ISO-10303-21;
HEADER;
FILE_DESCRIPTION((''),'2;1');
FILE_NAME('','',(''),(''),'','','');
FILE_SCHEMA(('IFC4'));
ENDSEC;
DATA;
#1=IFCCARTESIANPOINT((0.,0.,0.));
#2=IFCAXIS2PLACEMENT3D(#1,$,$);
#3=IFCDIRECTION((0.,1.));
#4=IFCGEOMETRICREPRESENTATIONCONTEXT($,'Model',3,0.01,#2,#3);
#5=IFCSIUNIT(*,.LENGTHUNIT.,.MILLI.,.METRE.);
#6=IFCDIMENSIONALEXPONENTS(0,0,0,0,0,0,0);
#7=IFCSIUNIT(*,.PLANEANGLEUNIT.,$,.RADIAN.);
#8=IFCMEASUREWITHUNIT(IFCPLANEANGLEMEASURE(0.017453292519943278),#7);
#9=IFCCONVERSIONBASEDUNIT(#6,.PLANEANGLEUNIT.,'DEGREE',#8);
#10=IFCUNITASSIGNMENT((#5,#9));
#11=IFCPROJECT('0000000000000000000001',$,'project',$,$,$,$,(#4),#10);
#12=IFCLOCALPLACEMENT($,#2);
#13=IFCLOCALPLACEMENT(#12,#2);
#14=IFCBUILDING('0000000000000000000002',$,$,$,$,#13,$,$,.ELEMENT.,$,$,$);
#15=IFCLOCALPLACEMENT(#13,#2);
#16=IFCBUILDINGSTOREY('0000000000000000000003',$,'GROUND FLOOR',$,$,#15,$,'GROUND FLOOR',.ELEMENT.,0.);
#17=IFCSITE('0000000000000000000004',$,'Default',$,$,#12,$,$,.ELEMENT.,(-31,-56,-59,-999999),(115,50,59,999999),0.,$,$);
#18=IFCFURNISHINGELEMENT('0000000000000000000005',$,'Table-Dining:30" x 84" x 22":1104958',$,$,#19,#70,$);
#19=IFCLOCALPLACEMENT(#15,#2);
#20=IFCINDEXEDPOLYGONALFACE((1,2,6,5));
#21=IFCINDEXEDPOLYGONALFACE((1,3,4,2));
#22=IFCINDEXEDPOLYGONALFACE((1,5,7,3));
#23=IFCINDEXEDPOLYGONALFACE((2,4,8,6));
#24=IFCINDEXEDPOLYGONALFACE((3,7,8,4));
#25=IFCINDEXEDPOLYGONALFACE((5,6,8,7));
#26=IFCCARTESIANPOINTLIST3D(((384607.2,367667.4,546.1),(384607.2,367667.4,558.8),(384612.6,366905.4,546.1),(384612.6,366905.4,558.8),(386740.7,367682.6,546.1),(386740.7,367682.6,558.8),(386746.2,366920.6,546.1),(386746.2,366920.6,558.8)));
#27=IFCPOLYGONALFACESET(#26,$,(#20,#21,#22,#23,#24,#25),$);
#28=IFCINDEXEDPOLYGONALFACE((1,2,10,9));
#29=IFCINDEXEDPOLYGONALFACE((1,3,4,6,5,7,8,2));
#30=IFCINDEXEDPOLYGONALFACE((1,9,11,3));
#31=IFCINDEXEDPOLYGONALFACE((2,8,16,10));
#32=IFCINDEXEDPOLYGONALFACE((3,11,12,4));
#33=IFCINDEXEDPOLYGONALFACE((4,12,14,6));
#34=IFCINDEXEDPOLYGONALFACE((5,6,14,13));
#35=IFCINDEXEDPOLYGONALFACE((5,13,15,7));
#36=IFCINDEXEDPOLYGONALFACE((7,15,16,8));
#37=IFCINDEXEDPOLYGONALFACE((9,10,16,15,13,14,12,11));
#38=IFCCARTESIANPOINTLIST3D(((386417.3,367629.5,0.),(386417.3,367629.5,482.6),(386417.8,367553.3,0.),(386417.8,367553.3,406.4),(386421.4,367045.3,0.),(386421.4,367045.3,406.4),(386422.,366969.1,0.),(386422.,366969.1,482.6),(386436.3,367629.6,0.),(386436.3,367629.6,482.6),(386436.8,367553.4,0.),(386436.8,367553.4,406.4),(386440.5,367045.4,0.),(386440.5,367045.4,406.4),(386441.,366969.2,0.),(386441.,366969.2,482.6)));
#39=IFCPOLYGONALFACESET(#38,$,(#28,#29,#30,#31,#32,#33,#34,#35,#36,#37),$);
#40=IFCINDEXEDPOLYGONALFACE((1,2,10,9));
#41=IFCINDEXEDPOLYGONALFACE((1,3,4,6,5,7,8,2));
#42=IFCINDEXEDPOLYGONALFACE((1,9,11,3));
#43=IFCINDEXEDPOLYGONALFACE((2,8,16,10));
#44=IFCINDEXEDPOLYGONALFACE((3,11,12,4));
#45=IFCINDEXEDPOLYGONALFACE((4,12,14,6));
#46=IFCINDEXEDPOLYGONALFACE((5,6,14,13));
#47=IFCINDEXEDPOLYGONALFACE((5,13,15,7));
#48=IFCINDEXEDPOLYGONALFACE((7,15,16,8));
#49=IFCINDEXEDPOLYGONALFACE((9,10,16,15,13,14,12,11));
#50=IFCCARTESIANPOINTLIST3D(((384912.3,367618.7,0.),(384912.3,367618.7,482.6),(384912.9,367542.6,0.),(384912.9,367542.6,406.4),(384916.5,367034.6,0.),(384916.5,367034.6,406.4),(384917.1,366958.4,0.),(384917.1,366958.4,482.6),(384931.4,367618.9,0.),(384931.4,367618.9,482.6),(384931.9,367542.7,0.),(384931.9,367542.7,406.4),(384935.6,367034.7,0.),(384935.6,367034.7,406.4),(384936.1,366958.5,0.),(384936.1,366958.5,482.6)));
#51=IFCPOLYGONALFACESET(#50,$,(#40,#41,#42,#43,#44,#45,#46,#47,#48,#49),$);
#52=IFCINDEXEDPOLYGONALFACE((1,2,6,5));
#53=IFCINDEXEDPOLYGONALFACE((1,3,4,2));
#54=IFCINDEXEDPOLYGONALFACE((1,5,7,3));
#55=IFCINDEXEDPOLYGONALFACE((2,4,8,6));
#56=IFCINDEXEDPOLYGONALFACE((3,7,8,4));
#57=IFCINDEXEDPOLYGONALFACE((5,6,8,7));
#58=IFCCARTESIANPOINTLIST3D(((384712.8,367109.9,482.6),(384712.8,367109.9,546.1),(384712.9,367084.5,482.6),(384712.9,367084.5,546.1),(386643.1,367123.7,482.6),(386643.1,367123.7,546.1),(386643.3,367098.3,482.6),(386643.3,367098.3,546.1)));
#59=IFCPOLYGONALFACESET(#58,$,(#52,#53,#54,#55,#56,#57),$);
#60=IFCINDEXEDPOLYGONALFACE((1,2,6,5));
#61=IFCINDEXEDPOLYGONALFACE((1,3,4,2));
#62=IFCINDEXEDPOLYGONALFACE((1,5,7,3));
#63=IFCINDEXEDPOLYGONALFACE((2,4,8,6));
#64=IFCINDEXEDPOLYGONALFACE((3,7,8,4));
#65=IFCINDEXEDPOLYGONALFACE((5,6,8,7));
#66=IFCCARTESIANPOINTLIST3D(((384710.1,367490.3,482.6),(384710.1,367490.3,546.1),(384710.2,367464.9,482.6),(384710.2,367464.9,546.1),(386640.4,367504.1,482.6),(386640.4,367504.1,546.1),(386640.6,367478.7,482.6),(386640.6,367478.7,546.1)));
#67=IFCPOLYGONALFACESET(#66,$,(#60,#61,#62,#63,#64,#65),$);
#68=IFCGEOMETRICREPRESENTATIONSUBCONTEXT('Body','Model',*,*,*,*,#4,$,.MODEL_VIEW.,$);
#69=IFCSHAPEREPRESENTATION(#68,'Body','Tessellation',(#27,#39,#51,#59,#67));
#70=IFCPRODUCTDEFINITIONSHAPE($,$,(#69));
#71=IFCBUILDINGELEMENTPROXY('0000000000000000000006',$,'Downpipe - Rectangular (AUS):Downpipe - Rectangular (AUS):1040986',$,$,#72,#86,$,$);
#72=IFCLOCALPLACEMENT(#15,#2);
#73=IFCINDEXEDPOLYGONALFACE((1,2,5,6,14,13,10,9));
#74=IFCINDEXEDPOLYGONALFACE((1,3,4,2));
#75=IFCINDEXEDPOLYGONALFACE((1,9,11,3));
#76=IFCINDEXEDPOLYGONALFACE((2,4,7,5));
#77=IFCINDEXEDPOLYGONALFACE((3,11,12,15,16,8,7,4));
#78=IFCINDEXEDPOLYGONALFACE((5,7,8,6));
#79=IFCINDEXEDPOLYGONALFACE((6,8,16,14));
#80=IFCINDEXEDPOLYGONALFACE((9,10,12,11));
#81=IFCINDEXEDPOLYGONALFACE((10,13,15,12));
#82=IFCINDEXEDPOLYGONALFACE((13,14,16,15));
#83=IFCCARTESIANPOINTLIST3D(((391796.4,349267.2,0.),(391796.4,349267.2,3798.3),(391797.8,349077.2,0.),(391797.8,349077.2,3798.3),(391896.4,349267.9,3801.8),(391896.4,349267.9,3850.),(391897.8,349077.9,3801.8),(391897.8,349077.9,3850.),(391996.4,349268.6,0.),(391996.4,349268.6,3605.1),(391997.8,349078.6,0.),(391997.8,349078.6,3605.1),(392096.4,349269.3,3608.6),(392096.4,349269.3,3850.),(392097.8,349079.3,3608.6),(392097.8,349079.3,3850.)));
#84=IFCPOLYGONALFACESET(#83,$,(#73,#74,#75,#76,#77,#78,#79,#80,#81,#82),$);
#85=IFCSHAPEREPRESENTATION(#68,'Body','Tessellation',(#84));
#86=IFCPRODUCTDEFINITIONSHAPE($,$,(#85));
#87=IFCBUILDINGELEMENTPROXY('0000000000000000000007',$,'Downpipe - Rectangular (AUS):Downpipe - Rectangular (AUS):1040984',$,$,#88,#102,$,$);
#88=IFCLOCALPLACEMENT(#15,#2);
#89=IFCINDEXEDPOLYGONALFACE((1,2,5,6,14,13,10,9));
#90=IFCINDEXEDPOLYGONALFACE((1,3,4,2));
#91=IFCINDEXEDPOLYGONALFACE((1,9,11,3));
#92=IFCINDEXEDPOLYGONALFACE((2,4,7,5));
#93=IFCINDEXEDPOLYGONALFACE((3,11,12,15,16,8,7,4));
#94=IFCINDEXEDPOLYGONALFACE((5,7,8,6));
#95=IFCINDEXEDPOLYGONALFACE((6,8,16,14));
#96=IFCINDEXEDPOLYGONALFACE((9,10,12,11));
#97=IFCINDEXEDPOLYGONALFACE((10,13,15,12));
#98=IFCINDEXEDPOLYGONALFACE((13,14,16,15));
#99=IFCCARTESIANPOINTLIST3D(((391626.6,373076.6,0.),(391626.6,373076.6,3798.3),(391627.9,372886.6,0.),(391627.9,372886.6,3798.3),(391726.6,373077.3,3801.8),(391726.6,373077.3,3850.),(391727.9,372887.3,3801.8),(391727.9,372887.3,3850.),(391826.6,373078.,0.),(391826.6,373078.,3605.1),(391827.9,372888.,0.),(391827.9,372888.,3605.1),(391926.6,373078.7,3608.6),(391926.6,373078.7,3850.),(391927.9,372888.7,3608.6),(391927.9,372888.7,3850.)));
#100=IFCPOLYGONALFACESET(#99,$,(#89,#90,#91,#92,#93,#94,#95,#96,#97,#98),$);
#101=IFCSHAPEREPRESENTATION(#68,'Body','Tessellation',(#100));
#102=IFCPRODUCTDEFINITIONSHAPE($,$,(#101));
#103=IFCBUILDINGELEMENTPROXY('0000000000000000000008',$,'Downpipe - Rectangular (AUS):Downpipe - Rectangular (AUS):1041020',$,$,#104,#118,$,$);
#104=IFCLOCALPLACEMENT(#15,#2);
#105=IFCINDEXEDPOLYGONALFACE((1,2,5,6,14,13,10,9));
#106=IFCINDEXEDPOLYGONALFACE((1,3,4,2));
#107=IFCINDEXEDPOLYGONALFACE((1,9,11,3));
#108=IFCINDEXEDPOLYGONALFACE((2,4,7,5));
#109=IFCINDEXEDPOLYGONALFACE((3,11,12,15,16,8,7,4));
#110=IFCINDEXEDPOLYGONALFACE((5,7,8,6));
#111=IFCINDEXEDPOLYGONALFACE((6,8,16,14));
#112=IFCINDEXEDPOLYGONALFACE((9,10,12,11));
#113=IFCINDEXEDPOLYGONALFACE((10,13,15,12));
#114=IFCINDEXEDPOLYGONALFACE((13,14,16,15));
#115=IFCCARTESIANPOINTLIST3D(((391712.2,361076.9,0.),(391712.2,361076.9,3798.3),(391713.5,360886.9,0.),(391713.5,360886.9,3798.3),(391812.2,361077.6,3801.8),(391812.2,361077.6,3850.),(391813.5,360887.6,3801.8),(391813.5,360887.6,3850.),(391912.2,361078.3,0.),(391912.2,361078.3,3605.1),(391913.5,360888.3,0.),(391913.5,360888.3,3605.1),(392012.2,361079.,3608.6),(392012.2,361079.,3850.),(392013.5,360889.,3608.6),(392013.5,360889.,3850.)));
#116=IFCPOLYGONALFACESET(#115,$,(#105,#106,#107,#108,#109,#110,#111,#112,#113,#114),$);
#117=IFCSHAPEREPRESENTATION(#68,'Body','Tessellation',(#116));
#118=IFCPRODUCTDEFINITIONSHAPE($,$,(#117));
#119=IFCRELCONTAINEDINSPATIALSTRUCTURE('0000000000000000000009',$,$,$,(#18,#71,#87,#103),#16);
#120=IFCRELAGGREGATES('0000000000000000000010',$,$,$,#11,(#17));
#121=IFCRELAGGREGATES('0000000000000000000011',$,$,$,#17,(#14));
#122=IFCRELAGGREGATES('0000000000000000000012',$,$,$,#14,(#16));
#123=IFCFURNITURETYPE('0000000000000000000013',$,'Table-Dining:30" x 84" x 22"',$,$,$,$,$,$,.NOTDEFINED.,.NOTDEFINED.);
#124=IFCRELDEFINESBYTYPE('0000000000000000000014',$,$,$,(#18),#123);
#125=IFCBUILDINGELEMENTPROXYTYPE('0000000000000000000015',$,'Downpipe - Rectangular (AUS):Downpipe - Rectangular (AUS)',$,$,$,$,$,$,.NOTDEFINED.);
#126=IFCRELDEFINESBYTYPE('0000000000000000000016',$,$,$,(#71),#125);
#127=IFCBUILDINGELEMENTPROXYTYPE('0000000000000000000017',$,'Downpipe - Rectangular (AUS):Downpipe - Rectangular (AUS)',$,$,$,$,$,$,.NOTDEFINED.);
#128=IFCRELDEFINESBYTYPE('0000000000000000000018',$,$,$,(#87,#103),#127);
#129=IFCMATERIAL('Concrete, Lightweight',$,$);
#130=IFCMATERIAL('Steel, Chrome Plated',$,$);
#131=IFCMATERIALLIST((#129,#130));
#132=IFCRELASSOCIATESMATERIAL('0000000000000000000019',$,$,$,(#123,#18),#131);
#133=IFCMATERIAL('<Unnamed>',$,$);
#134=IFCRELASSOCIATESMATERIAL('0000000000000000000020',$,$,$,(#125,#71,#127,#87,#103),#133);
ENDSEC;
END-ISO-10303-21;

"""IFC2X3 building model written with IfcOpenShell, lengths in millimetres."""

from ifc_helpers import new_model, entity, si_unit, converted_unit, direction, frame, frame_2d, origin, origin_2d_with_axis, place, context, subcontext, project, spatial, polyline, rectangle, outline, extrude, source, transform, mapped, material, material_list, type_object, type_shapes, element, save


model = new_model("IFC2X3")

# Units and contexts
model_context = context("Model", 3, precision=0.01, world=origin(), true_north=direction((0.0, 1.0)))
body_context = subcontext(model_context, "Body", "Model", "MODEL_VIEW")
ifc_project = project(units=[si_unit("LENGTHUNIT", "METRE", prefix="MILLI"), converted_unit("PLANEANGLEUNIT", "DEGREE", entity("IfcPlaneAngleMeasure", 0.017453292519943278), si_unit("PLANEANGLEUNIT", "RADIAN"), dimensions=[0, 0, 0, 0, 0, 0, 0])], contexts=[model_context])

# Site, building, storey
site_placement = place(None, origin())
site = spatial("IfcSite", under=ifc_project, at=site_placement, Name="Default", CompositionType="ELEMENT", RefLatitude=(-31, -56, -59, -999999), RefLongitude=(115, 50, 59, 999999), RefElevation=0.0)
building_placement = place(site_placement, origin())
building = spatial("IfcBuilding", under=site, at=building_placement, CompositionType="ELEMENT")
storey_placement = place(building_placement, origin())
storey = spatial("IfcBuildingStorey", under=building, at=storey_placement, Name="GROUND FLOOR", LongName="GROUND FLOOR", CompositionType="ELEMENT", Elevation=0.0)

# Furnishing element
ifc_material_1 = material(Name="Steel, Chrome Plated")
ifc_material_2 = material(Name="Concrete, Lightweight")
ifc_material_list_1 = material_list([ifc_material_2, ifc_material_1])
furniture_type_1 = type_object("IfcFurnitureType", Name="Table-Dining:30\" x 84\" x 22\"", AssemblyPlace="NOTDEFINED", material=ifc_material_list_1)
shared_shape_1 = source(origin(), body_context, "Body", "SweptSolid", [
    extrude(rectangle(XDim=2133.6, YDim=762.0, at=origin_2d_with_axis()), frame((18.3, 95.2, 546.1), z_axis=(0.0, 0.0, 1.0), x_axis=(-1.0, 0.0, 0.0)), (0.0, 0.0, 1.0), 12.7),
    extrude(outline(polyline([(-330.2, -260.3), (330.2, -260.3), (330.2, 222.2), (254.0, 222.2), (254.0, -184.1), (-254.0, -184.1), (-254.0, 222.2), (-330.2, 222.2), (-330.2, -260.3)])), frame((-743.7, 95.2, 222.2), z_axis=(1.0, 0.0, 0.0), x_axis=(0.0, -1.0, 0.0)), (0.0, 0.0, 1.0), 19.1),
    extrude(outline(polyline([(-222.2, -330.2), (260.3, -330.2), (260.3, 330.2), (-222.2, 330.2), (-222.2, 254.0), (184.1, 254.0), (184.1, -254.0), (-222.2, -254.0), (-222.2, -330.2)])), frame((761.2, 95.2, 222.2), z_axis=(1.0, 0.0, 0.0), x_axis=(0.0, 0.0, 1.0)), (0.0, 0.0, 1.0), 19.1),
    extrude(rectangle(XDim=1930.4, YDim=25.4, at=frame_2d((0.0, 0.0), x_axis=(1.0, 0.0))), frame((18.3, 285.1, 482.6), z_axis=(0.0, 0.0, 1.0), x_axis=(-1.0, 0.0, 0.0)), (0.0, 0.0, 1.0), 63.5),
    extrude(rectangle(XDim=1930.4, YDim=25.4, at=origin_2d_with_axis()), frame((18.3, -95.3, 482.6), z_axis=(0.0, 0.0, 1.0), x_axis=(-1.0, 0.0, 0.0)), (0.0, 0.0, 1.0), 63.5),
])
type_shapes(furniture_type_1, [shared_shape_1])
furnishing_1_placement = place(storey_placement, frame((385694.3, 367389.3, 0.0), z_axis=(0.0, 0.0, 1.0), x_axis=(-0.999975, -0.007134, 0.0)))
element("IfcFurnishingElement", 1, at=furnishing_1_placement, inside=storey, type_object=furniture_type_1, material=ifc_material_list_1, Name="Table-Dining:30\" x 84\" x 22\":1104958", context=body_context, shape_type="MappedRepresentation", body=[
    mapped(shared_shape_1, transform((0.0, 0.0, 0.0), scale=1.0)),
])

# Building element proxies
ifc_material_3 = material(Name="<Unnamed>")
building_element_proxy_type_1 = type_object("IfcBuildingElementProxyType", Name="Downpipe - Rectangular (AUS):Downpipe - Rectangular (AUS)", PredefinedType="NOTDEFINED", material=ifc_material_3)
shared_shape_2 = source(origin(), body_context, "Body", "SweptSolid", [
    extrude(outline(polyline([(-2814.2, -150.0), (984.1, -150.0), (987.5, -50.0), (1035.8, -50.0), (1035.8, 150.0), (794.4, 150.0), (790.9, 50.0), (-2814.2, 50.0), (-2814.2, -150.0)])), frame((100.0, -95.0, 2814.2), z_axis=(0.0, 1.0, 0.0), x_axis=(0.0, 0.0, 1.0)), (0.0, 0.0, 1.0), 190.0),
])
type_shapes(building_element_proxy_type_1, [shared_shape_2])
proxy_placement = place(storey_placement, frame((391847.1, 349172.6, 0.0), z_axis=(0.0, 0.0, 1.0), x_axis=(0.999975, 0.007134, 0.0)))
element("IfcBuildingElementProxy", 2, at=proxy_placement, inside=storey, type_object=building_element_proxy_type_1, material=ifc_material_3, Name="Downpipe - Rectangular (AUS):Downpipe - Rectangular (AUS):1040986", context=body_context, shape_type="MappedRepresentation", body=[
    mapped(shared_shape_2, transform((0.0, 0.0, 0.0), scale=1.0)),
])
building_element_proxy_type_2 = type_object("IfcBuildingElementProxyType", Name="Downpipe - Rectangular (AUS):Downpipe - Rectangular (AUS)", PredefinedType="NOTDEFINED", material=ifc_material_3)
shared_shape_3 = source(origin(), body_context, "Body", "SweptSolid", [
    extrude(outline(polyline([(-50.0, -2814.2), (150.0, -2814.2), (150.0, 984.1), (50.0, 987.5), (50.0, 1035.8), (-150.0, 1035.8), (-150.0, 794.4), (-50.0, 790.9), (-50.0, -2814.2)])), frame((100.0, -95.0, 2814.2), z_axis=(0.0, 1.0, 0.0), x_axis=(-1.0, 0.0, 0.0)), (0.0, 0.0, 1.0), 190.0),
])
type_shapes(building_element_proxy_type_2, [shared_shape_3])
for number, where, z_axis, x_axis, name in (
    (3, (391677.3, 372981.9, 0.0), (0.0, 0.0, 1.0), (0.999975, 0.007134, 0.0), "Downpipe - Rectangular (AUS):Downpipe - Rectangular (AUS):1040984"),
    (4, (391762.9, 360982.3, 0.0), (0.0, 0.0, 1.0), (0.999975, 0.007134, 0.0), "Downpipe - Rectangular (AUS):Downpipe - Rectangular (AUS):1041020"),
):
    element("IfcBuildingElementProxy", number, at=place(storey_placement, frame(where, z_axis=z_axis, x_axis=x_axis)), inside=storey, type_object=building_element_proxy_type_2, material=ifc_material_3, Name=name, context=body_context, shape_type="MappedRepresentation", body=[
        mapped(shared_shape_3, transform((0.0, 0.0, 0.0), scale=1.0)),
    ])

save(model, "model.ifc")
